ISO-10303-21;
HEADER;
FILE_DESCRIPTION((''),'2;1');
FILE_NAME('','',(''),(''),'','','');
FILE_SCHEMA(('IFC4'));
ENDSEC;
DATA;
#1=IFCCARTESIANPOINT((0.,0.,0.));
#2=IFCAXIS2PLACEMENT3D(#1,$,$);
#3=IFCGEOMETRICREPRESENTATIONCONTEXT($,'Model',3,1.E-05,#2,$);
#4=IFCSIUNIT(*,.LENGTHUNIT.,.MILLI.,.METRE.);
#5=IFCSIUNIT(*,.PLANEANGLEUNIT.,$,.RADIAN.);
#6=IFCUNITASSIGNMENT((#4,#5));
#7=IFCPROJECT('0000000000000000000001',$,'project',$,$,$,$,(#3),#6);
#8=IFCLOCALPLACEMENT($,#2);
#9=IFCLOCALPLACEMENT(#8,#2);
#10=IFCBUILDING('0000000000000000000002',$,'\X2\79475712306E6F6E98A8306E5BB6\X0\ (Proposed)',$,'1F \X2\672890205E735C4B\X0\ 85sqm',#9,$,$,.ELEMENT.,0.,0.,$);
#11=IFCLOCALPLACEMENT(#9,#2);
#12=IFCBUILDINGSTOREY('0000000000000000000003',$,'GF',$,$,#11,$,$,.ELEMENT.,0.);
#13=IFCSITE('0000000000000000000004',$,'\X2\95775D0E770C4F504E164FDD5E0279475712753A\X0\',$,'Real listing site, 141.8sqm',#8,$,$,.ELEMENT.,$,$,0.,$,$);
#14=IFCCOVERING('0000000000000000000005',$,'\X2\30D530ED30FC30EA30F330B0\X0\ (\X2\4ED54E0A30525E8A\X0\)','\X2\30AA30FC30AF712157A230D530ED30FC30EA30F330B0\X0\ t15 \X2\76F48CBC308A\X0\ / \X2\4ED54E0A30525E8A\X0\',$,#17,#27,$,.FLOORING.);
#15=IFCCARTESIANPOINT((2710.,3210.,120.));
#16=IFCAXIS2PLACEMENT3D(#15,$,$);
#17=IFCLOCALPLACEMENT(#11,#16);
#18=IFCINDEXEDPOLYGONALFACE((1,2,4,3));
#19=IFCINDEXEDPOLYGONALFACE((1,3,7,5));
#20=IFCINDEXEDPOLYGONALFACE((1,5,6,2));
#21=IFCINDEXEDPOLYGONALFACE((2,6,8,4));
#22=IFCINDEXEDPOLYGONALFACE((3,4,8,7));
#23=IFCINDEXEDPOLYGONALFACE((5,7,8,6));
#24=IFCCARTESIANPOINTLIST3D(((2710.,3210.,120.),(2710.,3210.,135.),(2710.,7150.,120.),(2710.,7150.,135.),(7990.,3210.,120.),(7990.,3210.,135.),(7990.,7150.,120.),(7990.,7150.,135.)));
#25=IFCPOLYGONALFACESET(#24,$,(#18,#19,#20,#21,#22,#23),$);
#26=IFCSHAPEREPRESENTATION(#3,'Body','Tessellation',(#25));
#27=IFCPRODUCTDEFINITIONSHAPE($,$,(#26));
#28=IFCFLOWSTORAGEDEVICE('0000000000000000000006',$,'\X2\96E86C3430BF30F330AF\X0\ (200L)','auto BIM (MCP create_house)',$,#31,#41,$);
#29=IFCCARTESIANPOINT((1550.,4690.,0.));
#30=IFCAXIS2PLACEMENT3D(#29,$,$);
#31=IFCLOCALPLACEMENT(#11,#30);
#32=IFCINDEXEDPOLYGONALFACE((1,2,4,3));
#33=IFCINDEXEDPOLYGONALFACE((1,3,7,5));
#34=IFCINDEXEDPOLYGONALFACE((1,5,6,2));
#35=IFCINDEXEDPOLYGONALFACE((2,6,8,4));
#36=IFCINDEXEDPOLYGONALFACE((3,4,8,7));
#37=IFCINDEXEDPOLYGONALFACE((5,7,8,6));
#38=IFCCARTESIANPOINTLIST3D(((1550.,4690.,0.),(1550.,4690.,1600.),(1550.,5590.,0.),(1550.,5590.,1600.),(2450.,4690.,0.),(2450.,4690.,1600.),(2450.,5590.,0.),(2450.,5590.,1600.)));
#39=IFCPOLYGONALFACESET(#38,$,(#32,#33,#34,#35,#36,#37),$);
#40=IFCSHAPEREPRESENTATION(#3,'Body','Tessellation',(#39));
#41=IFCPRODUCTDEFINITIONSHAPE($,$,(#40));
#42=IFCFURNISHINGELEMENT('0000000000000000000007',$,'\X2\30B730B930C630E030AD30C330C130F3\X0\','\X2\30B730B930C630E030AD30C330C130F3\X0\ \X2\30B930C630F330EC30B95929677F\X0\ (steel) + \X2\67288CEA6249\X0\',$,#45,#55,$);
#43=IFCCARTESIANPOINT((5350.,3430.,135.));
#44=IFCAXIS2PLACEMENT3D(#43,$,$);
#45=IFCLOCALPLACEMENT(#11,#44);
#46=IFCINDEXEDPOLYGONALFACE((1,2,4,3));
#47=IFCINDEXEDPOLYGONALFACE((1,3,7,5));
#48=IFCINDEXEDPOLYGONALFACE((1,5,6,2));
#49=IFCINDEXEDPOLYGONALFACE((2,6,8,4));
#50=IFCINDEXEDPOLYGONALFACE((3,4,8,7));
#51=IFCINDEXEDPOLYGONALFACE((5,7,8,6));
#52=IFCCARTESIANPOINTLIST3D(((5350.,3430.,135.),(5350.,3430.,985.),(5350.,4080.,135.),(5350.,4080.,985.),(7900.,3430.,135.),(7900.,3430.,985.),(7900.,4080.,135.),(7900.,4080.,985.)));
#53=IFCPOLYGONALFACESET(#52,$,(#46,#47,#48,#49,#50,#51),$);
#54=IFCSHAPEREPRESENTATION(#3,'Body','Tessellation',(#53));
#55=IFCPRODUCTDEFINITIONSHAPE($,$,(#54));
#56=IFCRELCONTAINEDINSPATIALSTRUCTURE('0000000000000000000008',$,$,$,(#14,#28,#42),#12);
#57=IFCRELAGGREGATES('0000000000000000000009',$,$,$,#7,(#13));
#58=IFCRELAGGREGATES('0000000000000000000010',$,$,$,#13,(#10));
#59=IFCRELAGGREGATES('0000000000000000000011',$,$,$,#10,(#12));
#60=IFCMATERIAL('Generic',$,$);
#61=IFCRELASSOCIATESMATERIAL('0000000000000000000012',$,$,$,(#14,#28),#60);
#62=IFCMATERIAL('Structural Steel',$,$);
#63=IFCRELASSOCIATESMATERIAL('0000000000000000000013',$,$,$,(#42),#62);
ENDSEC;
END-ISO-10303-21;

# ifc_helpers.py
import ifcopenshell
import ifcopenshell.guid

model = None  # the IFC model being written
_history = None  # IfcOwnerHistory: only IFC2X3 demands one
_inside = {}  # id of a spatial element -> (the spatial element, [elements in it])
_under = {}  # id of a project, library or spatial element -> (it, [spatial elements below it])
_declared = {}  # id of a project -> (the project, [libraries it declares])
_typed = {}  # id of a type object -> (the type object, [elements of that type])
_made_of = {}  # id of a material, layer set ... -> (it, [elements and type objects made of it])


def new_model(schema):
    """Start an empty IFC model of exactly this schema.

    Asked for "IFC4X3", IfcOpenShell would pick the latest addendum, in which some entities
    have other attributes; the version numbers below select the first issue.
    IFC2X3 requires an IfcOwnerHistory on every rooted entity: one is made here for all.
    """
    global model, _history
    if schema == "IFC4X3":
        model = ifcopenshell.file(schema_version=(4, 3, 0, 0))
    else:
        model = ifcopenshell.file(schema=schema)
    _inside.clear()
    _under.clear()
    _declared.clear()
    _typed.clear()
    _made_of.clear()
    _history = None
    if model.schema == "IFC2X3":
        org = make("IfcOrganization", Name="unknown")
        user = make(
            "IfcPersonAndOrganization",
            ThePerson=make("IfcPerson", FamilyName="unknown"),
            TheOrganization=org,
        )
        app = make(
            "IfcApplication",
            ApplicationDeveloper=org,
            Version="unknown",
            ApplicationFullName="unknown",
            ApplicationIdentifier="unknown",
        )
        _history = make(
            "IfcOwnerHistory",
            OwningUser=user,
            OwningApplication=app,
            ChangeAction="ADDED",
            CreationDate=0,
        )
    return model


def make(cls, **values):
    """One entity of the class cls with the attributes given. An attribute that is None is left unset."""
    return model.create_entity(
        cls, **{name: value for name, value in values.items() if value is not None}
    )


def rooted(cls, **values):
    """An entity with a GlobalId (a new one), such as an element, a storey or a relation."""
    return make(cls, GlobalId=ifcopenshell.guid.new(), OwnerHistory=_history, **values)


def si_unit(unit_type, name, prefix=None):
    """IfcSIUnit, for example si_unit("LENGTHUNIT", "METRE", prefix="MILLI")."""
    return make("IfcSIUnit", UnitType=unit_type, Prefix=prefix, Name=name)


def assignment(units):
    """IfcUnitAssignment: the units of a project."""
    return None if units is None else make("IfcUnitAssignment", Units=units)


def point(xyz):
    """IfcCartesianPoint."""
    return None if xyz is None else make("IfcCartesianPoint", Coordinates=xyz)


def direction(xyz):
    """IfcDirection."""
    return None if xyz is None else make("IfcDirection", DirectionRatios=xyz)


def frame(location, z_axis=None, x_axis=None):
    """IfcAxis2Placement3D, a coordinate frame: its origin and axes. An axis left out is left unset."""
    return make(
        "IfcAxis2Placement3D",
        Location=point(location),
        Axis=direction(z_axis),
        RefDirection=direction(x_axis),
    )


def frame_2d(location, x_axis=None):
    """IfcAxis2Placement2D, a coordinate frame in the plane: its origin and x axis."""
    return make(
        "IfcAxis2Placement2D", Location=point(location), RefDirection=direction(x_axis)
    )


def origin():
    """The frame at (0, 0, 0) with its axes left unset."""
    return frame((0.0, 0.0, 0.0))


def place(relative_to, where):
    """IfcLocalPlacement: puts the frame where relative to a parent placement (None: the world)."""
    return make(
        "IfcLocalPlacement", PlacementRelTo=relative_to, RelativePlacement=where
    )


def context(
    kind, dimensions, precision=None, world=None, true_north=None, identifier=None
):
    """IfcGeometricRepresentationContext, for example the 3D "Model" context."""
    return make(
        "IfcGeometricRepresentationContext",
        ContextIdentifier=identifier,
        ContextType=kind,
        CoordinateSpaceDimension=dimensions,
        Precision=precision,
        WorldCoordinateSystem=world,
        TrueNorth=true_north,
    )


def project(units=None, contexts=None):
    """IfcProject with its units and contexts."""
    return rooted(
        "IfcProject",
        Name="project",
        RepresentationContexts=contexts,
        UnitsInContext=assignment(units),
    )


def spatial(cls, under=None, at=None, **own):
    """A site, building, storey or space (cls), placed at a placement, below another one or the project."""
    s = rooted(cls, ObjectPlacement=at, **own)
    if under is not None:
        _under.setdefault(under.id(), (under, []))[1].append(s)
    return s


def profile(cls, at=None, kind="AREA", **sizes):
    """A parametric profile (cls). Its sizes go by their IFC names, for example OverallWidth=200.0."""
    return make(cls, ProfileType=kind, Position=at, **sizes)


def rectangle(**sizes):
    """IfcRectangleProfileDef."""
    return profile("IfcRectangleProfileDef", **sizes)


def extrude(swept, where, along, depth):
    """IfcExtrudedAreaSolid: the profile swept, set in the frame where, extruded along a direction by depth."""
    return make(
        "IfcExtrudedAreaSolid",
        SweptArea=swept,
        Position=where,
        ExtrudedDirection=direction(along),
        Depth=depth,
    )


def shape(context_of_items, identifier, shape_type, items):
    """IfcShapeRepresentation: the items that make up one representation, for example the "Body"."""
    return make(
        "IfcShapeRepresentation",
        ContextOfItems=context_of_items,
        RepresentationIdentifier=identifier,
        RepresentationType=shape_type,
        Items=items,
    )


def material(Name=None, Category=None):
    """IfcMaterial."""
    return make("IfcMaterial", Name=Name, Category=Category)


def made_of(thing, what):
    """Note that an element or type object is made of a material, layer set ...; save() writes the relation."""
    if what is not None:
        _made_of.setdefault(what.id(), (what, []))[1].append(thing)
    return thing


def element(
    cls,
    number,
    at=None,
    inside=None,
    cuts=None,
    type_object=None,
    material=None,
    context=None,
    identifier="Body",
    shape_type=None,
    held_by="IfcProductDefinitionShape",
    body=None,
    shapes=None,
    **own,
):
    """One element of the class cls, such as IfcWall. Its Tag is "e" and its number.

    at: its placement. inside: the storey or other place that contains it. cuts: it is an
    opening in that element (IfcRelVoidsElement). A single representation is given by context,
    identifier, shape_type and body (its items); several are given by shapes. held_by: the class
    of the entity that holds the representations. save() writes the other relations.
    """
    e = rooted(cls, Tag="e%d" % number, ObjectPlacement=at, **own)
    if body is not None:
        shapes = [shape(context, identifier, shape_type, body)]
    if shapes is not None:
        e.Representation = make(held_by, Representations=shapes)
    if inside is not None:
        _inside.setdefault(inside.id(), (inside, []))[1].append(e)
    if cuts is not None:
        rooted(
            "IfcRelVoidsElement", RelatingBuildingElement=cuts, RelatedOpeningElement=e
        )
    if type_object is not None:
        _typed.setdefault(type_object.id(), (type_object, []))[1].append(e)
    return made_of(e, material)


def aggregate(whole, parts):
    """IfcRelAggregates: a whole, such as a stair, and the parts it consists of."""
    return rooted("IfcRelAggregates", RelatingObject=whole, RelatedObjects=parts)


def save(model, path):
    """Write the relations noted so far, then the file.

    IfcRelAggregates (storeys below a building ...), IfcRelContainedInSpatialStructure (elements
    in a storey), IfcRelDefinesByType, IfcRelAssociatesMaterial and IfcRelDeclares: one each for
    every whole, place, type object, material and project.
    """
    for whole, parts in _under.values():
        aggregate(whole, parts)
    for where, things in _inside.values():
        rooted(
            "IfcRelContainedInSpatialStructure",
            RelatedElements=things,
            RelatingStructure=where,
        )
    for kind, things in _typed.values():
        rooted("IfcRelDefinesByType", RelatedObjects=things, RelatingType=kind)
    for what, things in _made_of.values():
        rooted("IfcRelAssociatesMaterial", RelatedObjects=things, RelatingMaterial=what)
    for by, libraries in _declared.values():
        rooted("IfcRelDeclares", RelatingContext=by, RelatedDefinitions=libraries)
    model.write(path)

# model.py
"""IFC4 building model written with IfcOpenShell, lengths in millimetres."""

from ifc_helpers import new_model, si_unit, frame, frame_2d, origin, place, context, project, spatial, rectangle, extrude, material, element, save


model = new_model("IFC4")

# Units and contexts
model_context = context("Model", 3, precision=1e-05, world=origin())
ifc_project = project(units=[si_unit("LENGTHUNIT", "METRE", prefix="MILLI"), si_unit("PLANEANGLEUNIT", "RADIAN")], contexts=[model_context])

# Site, building, storey
site_placement = place(None, origin())
site = spatial("IfcSite", under=ifc_project, at=site_placement, Name="長崎県佐世保市祇園町", ObjectType="Real listing site, 141.8sqm", CompositionType="ELEMENT", RefElevation=0.0)
building_placement = place(site_placement, origin())
building = spatial("IfcBuilding", under=site, at=building_placement, Name="祇園の潮風の家 (Proposed)", ObjectType="1F 木造平屋 85sqm", CompositionType="ELEMENT", ElevationOfRefHeight=0.0, ElevationOfTerrain=0.0)
storey_placement = place(building_placement, origin())
storey = spatial("IfcBuildingStorey", under=building, at=storey_placement, Name="GF", CompositionType="ELEMENT", Elevation=0.0)

# Shared definitions
ifc_material_1 = material(Name="Generic")

# Covering
covering_placement = place(storey_placement, frame((2710.0, 3210.0, 120.0)))
element("IfcCovering", 1, at=covering_placement, inside=storey, material=ifc_material_1, Name="フローリング (仕上げ床)", Description="オーク無垢フローリング t15 直貼り / 仕上げ床", PredefinedType="FLOORING", context=model_context, shape_type="SweptSolid", body=[
    extrude(rectangle(XDim=5280.0, YDim=3940.0, at=frame_2d((2640.0, 1970.0))), frame((2710.0, 3210.0, 120.0)), (0.0, 0.0, 1.0), 15.0),
])

# Flow storage device
flow_storage_device_placement = place(storey_placement, frame((1550.0, 4690.0, 0.0)))
element("IfcFlowStorageDevice", 2, at=flow_storage_device_placement, inside=storey, material=ifc_material_1, Name="雨水タンク (200L)", Description="auto BIM (MCP create_house)", context=model_context, shape_type="SweptSolid", body=[
    extrude(rectangle(XDim=900.0, YDim=900.0, at=frame_2d((450.0, 450.0))), frame((1550.0, 4690.0, 0.0)), (0.0, 0.0, 1.0), 1600.0),
])

# Furnishing element
ifc_material_2 = material(Name="Structural Steel")
furnishing_placement = place(storey_placement, frame((5350.0, 3430.0, 135.0)))
element("IfcFurnishingElement", 3, at=furnishing_placement, inside=storey, material=ifc_material_2, Name="システムキッチン", Description="システムキッチン ステンレス天板 (steel) + 木質扉", context=model_context, shape_type="SweptSolid", body=[
    extrude(rectangle(XDim=2550.0, YDim=650.0, at=frame_2d((1275.0, 325.0))), frame((5350.0, 3430.0, 135.0)), (0.0, 0.0, 1.0), 850.0),
])

save(model, "model.ifc")
